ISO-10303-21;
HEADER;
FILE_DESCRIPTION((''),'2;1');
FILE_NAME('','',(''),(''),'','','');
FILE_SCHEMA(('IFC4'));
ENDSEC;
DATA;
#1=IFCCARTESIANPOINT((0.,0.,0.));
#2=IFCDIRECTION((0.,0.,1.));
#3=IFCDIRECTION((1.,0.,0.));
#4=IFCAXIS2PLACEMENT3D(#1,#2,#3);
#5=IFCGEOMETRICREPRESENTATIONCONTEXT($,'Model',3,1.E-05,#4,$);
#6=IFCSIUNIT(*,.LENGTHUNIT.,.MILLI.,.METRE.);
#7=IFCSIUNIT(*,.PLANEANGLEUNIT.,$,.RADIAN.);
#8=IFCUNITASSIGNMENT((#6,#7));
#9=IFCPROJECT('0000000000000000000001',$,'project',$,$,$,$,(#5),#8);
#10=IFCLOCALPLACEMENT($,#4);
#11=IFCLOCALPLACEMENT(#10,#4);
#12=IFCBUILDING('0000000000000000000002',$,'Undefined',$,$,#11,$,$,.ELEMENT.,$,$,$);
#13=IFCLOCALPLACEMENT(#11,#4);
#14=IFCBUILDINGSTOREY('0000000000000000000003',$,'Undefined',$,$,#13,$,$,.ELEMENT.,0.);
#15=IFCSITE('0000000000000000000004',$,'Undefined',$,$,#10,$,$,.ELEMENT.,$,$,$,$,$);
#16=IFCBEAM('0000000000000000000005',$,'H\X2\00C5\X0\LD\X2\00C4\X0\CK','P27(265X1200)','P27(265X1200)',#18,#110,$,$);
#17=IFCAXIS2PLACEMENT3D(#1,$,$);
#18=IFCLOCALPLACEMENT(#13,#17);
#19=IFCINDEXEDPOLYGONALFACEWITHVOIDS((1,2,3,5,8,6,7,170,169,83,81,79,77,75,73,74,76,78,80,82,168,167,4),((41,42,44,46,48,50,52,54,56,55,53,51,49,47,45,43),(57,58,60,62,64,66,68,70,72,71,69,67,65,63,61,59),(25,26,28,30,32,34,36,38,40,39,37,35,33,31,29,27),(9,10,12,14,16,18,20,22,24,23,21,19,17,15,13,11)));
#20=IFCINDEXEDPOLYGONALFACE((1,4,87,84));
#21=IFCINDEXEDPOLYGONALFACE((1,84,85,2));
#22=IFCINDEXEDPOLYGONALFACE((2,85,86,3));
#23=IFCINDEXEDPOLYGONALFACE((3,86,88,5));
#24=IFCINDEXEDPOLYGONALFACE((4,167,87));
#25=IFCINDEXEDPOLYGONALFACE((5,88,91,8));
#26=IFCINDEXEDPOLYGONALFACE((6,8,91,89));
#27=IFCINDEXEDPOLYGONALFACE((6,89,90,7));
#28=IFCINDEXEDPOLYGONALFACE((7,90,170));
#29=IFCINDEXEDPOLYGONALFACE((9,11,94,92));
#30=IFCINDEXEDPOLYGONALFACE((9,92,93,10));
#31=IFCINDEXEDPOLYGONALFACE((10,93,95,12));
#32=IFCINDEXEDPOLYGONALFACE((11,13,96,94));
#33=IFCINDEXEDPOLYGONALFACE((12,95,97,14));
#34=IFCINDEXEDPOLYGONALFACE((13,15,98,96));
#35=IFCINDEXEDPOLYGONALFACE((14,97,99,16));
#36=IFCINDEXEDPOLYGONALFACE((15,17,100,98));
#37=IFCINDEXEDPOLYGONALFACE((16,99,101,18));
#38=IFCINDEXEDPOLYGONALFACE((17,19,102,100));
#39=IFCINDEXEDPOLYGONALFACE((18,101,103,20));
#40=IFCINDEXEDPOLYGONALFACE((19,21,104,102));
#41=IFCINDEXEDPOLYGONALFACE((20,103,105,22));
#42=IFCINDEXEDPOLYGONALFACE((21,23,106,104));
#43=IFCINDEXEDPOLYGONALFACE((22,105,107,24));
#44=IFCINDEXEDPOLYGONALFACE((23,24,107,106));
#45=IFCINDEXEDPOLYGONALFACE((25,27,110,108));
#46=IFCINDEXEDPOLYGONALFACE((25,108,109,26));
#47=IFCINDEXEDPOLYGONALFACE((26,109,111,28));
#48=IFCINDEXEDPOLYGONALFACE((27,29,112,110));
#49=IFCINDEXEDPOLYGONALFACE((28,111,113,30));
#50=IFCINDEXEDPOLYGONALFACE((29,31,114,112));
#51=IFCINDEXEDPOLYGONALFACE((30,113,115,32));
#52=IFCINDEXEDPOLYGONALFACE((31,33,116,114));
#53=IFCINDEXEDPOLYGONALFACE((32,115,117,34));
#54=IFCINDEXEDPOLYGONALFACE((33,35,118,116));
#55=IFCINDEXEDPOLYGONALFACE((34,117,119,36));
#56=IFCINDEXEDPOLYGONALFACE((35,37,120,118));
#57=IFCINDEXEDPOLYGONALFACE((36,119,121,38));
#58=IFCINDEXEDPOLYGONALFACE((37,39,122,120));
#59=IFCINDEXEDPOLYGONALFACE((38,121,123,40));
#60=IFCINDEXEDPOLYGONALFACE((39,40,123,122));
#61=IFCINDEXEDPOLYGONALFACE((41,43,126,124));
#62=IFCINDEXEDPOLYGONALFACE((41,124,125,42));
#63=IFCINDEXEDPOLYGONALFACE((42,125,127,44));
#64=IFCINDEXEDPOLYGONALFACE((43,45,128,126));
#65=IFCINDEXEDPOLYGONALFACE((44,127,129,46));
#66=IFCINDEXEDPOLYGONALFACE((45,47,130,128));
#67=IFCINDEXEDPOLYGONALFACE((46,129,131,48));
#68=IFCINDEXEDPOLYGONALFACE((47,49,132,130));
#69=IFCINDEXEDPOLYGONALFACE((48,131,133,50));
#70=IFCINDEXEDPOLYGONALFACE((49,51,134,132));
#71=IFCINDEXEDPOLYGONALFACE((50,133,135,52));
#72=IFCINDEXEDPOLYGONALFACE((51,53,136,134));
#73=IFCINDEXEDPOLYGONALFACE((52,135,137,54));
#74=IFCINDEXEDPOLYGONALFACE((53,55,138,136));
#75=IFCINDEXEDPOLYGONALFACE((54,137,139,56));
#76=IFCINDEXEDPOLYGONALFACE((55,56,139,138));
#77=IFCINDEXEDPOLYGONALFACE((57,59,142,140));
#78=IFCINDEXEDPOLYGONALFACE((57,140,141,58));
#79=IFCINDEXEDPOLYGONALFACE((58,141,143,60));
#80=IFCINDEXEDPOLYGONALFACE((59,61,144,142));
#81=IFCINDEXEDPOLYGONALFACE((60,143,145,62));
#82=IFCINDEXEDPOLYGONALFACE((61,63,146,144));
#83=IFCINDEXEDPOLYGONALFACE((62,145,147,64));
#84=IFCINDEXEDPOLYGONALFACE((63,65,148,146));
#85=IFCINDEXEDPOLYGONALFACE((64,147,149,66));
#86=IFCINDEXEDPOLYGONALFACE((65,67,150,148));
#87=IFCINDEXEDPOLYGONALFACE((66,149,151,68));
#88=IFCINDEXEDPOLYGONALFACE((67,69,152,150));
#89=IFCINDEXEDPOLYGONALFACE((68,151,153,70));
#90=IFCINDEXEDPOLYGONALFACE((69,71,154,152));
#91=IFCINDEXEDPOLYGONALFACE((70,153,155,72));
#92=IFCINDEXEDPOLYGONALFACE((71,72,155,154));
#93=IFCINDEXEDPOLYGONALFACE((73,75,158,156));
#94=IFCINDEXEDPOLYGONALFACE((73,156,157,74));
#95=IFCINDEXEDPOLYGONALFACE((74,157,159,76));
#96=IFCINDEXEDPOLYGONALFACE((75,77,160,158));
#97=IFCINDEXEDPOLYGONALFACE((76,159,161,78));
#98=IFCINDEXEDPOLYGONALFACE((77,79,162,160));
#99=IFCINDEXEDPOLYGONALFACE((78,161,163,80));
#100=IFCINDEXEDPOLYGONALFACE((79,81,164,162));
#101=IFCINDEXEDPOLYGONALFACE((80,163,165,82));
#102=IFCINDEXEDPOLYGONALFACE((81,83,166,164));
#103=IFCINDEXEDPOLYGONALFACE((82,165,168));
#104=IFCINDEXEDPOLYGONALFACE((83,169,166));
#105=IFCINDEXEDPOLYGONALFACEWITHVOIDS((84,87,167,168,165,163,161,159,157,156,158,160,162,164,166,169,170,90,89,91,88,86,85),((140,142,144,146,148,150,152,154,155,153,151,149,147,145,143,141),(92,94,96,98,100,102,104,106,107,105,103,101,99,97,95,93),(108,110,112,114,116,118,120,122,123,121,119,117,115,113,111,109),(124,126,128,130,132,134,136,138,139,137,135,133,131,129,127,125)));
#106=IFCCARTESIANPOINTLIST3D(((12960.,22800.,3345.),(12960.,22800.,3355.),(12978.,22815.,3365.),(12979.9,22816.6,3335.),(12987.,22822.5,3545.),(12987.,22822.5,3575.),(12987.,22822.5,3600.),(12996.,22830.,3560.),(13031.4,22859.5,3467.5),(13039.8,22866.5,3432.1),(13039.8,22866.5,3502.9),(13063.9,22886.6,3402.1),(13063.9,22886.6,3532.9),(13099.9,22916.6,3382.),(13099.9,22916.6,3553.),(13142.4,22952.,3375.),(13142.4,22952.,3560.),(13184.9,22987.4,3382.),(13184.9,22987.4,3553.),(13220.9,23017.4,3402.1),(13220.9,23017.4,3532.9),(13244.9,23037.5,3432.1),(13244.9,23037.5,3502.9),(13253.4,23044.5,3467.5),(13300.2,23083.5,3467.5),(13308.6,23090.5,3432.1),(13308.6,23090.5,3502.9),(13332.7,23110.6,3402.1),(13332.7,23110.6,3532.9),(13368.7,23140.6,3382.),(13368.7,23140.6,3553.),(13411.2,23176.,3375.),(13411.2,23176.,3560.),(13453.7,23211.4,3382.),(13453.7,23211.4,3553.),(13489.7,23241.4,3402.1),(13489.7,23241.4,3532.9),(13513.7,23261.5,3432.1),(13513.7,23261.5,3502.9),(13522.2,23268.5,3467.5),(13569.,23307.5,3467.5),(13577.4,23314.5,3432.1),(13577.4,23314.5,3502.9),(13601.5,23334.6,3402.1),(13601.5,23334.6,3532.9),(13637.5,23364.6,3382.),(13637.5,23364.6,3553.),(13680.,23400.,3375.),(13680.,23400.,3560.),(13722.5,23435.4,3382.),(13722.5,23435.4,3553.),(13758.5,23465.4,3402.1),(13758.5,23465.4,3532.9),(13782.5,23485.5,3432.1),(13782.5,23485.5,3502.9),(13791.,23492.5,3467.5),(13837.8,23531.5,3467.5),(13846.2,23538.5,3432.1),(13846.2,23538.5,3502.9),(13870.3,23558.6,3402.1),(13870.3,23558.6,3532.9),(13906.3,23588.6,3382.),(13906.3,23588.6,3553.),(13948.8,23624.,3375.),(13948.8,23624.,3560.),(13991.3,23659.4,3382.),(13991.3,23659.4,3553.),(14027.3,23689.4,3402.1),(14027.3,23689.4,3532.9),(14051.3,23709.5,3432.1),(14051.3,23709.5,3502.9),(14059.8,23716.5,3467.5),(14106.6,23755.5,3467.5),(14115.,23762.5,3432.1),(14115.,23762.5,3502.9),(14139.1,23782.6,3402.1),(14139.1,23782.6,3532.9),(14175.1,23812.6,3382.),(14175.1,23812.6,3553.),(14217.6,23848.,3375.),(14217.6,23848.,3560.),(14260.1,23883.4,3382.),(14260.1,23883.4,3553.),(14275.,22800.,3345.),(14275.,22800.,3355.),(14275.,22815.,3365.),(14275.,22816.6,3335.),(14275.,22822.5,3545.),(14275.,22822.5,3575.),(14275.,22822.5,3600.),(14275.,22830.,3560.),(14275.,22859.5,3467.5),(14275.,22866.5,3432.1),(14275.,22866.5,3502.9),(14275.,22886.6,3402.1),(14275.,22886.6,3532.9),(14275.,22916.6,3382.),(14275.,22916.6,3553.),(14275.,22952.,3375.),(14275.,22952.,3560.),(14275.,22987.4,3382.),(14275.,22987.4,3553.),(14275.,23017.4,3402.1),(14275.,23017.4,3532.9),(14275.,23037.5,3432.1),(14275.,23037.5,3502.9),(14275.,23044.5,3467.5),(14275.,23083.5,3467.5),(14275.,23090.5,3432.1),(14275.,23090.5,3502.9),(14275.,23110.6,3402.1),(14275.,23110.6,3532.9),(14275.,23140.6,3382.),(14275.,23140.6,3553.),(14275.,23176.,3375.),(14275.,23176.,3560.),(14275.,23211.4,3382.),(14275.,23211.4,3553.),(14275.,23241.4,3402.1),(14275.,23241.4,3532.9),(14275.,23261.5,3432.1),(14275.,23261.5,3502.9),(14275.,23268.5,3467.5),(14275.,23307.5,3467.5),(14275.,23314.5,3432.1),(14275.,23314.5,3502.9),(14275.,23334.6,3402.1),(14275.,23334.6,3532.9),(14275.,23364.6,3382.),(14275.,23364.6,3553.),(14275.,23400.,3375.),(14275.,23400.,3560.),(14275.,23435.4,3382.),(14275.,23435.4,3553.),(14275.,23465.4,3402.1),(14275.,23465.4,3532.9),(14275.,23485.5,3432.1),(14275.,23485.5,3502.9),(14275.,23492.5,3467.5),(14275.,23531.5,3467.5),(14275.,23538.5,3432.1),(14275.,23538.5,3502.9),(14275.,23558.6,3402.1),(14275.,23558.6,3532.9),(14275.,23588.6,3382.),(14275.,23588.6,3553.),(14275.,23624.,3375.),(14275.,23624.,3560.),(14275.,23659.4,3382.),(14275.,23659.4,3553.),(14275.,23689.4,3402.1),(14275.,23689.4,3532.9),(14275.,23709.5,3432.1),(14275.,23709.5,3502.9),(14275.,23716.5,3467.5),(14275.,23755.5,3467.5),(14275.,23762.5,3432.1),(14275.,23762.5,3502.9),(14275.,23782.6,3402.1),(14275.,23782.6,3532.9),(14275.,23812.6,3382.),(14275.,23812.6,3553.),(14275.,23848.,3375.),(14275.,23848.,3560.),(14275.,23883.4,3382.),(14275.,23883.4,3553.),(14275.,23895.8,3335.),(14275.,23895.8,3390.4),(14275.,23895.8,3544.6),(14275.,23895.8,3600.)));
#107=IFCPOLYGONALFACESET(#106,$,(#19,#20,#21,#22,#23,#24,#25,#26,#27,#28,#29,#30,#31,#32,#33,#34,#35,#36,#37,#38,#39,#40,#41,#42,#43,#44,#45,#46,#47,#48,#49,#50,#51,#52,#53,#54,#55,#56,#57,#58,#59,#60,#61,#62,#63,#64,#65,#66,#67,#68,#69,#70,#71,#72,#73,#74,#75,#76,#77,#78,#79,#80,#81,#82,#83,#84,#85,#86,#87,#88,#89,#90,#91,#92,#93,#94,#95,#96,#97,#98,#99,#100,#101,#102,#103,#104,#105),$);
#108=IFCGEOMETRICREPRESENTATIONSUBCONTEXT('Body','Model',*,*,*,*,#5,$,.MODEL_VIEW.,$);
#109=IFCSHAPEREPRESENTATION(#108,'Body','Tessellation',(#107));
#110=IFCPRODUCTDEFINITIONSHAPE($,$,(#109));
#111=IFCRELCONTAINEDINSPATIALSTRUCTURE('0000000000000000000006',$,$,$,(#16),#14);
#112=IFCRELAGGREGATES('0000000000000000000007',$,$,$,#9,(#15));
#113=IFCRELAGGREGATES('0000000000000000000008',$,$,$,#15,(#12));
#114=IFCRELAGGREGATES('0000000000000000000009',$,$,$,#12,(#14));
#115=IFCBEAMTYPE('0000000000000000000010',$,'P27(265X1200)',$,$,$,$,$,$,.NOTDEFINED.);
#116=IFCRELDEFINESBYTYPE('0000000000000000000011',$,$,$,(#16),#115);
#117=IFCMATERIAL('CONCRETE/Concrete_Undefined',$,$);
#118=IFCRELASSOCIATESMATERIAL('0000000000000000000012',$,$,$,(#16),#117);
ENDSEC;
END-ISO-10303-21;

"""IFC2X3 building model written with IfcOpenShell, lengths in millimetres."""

from ifc_helpers import new_model, si_unit, frame, origin_with_axes, place, context, subcontext, project, spatial, polyline, outline, extrude, clip, halfspace, material, type_object, element, save


model = new_model("IFC2X3")

# Units and contexts
model_context = context("Model", 3, precision=1e-05, world=origin_with_axes())
body_context = subcontext(model_context, "Body", "Model", "MODEL_VIEW")
ifc_project = project(units=[si_unit("LENGTHUNIT", "METRE", prefix="MILLI"), si_unit("PLANEANGLEUNIT", "RADIAN")], contexts=[model_context])

# Site, building, storey
site_placement = place(None, origin_with_axes())
site = spatial("IfcSite", under=ifc_project, at=site_placement, Name="Undefined", CompositionType="ELEMENT")
building_placement = place(site_placement, origin_with_axes())
building = spatial("IfcBuilding", under=site, at=building_placement, Name="Undefined", CompositionType="ELEMENT")
storey_placement = place(building_placement, origin_with_axes())
storey = spatial("IfcBuildingStorey", under=building, at=storey_placement, Name="Undefined", CompositionType="ELEMENT", Elevation=0.0)

# Beam
ifc_material_1 = material(Name="CONCRETE/Concrete_Undefined")
beam_type_1 = type_object("IfcBeamType", Name="P27(265X1200)", PredefinedType="NOTDEFINED")
beam_1_placement = place(storey_placement, frame((12960.0, 23400.0, 3467.5), z_axis=(0.0, 0.0, 1.0), x_axis=(1.0, 0.0, 0.0)))
element("IfcBeam", 1, at=beam_1_placement, inside=storey, type_object=beam_type_1, material=ifc_material_1, Name="HÅLDÄCK", Description="P27(265X1200)", ObjectType="P27(265X1200)", context=body_context, shape_type="Clipping", body=[
    clip(extrude(outline(polyline([(-583.4, -132.5), (-600.0, -122.5), (-600.0, -112.5), (-585.0, -102.5), (-577.5, 77.5), (-570.0, 92.5), (-577.5, 107.5), (-577.5, 132.5), (577.5, 132.5), (577.5, 107.5), (570.0, 92.5), (577.5, 77.5), (585.0, -102.5), (600.0, -112.5), (600.0, -122.5), (583.4, -132.5), (-583.4, -132.5)]), holes=[polyline([(-513.4, 65.4), (-533.5, 35.4), (-540.5, 0.0), (-533.5, -35.4), (-513.4, -65.4), (-483.4, -85.5), (-448.0, -92.5), (-412.6, -85.5), (-382.6, -65.4), (-362.5, -35.4), (-355.5, 0.0), (-362.5, 35.4), (-382.6, 65.4), (-412.6, 85.5), (-448.0, 92.5), (-483.4, 85.5), (-513.4, 65.4)]), polyline([(-289.4, 65.4), (-309.5, 35.4), (-316.5, 0.0), (-309.5, -35.4), (-289.4, -65.4), (-259.4, -85.5), (-224.0, -92.5), (-188.6, -85.5), (-158.6, -65.4), (-138.5, -35.4), (-131.5, 0.0), (-138.5, 35.4), (-158.6, 65.4), (-188.6, 85.5), (-224.0, 92.5), (-259.4, 85.5), (-289.4, 65.4)]), polyline([(-65.4, 65.4), (-85.5, 35.4), (-92.5, 0.0), (-85.5, -35.4), (-65.4, -65.4), (-35.4, -85.5), (0.0, -92.5), (35.4, -85.5), (65.4, -65.4), (85.5, -35.4), (92.5, 0.0), (85.5, 35.4), (65.4, 65.4), (35.4, 85.5), (0.0, 92.5), (-35.4, 85.5), (-65.4, 65.4)]), polyline([(158.6, 65.4), (138.5, 35.4), (131.5, 0.0), (138.5, -35.4), (158.6, -65.4), (188.6, -85.5), (224.0, -92.5), (259.4, -85.5), (289.4, -65.4), (309.5, -35.4), (316.5, 0.0), (309.5, 35.4), (289.4, 65.4), (259.4, 85.5), (224.0, 92.5), (188.6, 85.5), (158.6, 65.4)]), polyline([(382.6, 65.4), (362.5, 35.4), (355.5, 0.0), (362.5, -35.4), (382.6, -65.4), (412.6, -85.5), (448.0, -92.5), (483.4, -85.5), (513.4, -65.4), (533.5, -35.4), (540.5, 0.0), (533.5, 35.4), (513.4, 65.4), (483.4, 85.5), (448.0, 92.5), (412.6, 85.5), (382.6, 65.4)])]), frame((1315.0, 0.0, 0.0), z_axis=(-1.0, 0.0, 0.0), x_axis=(0.0, -1.0, 0.0)), (0.0, 0.0, 1.0), 1315.0), halfspace(frame((1440.0, 600.0, -132.5), z_axis=(-0.640184, 0.768221, 0.0), x_axis=(0.0, 0.0, 1.0)), False)),
])

save(model, "model.ifc")
